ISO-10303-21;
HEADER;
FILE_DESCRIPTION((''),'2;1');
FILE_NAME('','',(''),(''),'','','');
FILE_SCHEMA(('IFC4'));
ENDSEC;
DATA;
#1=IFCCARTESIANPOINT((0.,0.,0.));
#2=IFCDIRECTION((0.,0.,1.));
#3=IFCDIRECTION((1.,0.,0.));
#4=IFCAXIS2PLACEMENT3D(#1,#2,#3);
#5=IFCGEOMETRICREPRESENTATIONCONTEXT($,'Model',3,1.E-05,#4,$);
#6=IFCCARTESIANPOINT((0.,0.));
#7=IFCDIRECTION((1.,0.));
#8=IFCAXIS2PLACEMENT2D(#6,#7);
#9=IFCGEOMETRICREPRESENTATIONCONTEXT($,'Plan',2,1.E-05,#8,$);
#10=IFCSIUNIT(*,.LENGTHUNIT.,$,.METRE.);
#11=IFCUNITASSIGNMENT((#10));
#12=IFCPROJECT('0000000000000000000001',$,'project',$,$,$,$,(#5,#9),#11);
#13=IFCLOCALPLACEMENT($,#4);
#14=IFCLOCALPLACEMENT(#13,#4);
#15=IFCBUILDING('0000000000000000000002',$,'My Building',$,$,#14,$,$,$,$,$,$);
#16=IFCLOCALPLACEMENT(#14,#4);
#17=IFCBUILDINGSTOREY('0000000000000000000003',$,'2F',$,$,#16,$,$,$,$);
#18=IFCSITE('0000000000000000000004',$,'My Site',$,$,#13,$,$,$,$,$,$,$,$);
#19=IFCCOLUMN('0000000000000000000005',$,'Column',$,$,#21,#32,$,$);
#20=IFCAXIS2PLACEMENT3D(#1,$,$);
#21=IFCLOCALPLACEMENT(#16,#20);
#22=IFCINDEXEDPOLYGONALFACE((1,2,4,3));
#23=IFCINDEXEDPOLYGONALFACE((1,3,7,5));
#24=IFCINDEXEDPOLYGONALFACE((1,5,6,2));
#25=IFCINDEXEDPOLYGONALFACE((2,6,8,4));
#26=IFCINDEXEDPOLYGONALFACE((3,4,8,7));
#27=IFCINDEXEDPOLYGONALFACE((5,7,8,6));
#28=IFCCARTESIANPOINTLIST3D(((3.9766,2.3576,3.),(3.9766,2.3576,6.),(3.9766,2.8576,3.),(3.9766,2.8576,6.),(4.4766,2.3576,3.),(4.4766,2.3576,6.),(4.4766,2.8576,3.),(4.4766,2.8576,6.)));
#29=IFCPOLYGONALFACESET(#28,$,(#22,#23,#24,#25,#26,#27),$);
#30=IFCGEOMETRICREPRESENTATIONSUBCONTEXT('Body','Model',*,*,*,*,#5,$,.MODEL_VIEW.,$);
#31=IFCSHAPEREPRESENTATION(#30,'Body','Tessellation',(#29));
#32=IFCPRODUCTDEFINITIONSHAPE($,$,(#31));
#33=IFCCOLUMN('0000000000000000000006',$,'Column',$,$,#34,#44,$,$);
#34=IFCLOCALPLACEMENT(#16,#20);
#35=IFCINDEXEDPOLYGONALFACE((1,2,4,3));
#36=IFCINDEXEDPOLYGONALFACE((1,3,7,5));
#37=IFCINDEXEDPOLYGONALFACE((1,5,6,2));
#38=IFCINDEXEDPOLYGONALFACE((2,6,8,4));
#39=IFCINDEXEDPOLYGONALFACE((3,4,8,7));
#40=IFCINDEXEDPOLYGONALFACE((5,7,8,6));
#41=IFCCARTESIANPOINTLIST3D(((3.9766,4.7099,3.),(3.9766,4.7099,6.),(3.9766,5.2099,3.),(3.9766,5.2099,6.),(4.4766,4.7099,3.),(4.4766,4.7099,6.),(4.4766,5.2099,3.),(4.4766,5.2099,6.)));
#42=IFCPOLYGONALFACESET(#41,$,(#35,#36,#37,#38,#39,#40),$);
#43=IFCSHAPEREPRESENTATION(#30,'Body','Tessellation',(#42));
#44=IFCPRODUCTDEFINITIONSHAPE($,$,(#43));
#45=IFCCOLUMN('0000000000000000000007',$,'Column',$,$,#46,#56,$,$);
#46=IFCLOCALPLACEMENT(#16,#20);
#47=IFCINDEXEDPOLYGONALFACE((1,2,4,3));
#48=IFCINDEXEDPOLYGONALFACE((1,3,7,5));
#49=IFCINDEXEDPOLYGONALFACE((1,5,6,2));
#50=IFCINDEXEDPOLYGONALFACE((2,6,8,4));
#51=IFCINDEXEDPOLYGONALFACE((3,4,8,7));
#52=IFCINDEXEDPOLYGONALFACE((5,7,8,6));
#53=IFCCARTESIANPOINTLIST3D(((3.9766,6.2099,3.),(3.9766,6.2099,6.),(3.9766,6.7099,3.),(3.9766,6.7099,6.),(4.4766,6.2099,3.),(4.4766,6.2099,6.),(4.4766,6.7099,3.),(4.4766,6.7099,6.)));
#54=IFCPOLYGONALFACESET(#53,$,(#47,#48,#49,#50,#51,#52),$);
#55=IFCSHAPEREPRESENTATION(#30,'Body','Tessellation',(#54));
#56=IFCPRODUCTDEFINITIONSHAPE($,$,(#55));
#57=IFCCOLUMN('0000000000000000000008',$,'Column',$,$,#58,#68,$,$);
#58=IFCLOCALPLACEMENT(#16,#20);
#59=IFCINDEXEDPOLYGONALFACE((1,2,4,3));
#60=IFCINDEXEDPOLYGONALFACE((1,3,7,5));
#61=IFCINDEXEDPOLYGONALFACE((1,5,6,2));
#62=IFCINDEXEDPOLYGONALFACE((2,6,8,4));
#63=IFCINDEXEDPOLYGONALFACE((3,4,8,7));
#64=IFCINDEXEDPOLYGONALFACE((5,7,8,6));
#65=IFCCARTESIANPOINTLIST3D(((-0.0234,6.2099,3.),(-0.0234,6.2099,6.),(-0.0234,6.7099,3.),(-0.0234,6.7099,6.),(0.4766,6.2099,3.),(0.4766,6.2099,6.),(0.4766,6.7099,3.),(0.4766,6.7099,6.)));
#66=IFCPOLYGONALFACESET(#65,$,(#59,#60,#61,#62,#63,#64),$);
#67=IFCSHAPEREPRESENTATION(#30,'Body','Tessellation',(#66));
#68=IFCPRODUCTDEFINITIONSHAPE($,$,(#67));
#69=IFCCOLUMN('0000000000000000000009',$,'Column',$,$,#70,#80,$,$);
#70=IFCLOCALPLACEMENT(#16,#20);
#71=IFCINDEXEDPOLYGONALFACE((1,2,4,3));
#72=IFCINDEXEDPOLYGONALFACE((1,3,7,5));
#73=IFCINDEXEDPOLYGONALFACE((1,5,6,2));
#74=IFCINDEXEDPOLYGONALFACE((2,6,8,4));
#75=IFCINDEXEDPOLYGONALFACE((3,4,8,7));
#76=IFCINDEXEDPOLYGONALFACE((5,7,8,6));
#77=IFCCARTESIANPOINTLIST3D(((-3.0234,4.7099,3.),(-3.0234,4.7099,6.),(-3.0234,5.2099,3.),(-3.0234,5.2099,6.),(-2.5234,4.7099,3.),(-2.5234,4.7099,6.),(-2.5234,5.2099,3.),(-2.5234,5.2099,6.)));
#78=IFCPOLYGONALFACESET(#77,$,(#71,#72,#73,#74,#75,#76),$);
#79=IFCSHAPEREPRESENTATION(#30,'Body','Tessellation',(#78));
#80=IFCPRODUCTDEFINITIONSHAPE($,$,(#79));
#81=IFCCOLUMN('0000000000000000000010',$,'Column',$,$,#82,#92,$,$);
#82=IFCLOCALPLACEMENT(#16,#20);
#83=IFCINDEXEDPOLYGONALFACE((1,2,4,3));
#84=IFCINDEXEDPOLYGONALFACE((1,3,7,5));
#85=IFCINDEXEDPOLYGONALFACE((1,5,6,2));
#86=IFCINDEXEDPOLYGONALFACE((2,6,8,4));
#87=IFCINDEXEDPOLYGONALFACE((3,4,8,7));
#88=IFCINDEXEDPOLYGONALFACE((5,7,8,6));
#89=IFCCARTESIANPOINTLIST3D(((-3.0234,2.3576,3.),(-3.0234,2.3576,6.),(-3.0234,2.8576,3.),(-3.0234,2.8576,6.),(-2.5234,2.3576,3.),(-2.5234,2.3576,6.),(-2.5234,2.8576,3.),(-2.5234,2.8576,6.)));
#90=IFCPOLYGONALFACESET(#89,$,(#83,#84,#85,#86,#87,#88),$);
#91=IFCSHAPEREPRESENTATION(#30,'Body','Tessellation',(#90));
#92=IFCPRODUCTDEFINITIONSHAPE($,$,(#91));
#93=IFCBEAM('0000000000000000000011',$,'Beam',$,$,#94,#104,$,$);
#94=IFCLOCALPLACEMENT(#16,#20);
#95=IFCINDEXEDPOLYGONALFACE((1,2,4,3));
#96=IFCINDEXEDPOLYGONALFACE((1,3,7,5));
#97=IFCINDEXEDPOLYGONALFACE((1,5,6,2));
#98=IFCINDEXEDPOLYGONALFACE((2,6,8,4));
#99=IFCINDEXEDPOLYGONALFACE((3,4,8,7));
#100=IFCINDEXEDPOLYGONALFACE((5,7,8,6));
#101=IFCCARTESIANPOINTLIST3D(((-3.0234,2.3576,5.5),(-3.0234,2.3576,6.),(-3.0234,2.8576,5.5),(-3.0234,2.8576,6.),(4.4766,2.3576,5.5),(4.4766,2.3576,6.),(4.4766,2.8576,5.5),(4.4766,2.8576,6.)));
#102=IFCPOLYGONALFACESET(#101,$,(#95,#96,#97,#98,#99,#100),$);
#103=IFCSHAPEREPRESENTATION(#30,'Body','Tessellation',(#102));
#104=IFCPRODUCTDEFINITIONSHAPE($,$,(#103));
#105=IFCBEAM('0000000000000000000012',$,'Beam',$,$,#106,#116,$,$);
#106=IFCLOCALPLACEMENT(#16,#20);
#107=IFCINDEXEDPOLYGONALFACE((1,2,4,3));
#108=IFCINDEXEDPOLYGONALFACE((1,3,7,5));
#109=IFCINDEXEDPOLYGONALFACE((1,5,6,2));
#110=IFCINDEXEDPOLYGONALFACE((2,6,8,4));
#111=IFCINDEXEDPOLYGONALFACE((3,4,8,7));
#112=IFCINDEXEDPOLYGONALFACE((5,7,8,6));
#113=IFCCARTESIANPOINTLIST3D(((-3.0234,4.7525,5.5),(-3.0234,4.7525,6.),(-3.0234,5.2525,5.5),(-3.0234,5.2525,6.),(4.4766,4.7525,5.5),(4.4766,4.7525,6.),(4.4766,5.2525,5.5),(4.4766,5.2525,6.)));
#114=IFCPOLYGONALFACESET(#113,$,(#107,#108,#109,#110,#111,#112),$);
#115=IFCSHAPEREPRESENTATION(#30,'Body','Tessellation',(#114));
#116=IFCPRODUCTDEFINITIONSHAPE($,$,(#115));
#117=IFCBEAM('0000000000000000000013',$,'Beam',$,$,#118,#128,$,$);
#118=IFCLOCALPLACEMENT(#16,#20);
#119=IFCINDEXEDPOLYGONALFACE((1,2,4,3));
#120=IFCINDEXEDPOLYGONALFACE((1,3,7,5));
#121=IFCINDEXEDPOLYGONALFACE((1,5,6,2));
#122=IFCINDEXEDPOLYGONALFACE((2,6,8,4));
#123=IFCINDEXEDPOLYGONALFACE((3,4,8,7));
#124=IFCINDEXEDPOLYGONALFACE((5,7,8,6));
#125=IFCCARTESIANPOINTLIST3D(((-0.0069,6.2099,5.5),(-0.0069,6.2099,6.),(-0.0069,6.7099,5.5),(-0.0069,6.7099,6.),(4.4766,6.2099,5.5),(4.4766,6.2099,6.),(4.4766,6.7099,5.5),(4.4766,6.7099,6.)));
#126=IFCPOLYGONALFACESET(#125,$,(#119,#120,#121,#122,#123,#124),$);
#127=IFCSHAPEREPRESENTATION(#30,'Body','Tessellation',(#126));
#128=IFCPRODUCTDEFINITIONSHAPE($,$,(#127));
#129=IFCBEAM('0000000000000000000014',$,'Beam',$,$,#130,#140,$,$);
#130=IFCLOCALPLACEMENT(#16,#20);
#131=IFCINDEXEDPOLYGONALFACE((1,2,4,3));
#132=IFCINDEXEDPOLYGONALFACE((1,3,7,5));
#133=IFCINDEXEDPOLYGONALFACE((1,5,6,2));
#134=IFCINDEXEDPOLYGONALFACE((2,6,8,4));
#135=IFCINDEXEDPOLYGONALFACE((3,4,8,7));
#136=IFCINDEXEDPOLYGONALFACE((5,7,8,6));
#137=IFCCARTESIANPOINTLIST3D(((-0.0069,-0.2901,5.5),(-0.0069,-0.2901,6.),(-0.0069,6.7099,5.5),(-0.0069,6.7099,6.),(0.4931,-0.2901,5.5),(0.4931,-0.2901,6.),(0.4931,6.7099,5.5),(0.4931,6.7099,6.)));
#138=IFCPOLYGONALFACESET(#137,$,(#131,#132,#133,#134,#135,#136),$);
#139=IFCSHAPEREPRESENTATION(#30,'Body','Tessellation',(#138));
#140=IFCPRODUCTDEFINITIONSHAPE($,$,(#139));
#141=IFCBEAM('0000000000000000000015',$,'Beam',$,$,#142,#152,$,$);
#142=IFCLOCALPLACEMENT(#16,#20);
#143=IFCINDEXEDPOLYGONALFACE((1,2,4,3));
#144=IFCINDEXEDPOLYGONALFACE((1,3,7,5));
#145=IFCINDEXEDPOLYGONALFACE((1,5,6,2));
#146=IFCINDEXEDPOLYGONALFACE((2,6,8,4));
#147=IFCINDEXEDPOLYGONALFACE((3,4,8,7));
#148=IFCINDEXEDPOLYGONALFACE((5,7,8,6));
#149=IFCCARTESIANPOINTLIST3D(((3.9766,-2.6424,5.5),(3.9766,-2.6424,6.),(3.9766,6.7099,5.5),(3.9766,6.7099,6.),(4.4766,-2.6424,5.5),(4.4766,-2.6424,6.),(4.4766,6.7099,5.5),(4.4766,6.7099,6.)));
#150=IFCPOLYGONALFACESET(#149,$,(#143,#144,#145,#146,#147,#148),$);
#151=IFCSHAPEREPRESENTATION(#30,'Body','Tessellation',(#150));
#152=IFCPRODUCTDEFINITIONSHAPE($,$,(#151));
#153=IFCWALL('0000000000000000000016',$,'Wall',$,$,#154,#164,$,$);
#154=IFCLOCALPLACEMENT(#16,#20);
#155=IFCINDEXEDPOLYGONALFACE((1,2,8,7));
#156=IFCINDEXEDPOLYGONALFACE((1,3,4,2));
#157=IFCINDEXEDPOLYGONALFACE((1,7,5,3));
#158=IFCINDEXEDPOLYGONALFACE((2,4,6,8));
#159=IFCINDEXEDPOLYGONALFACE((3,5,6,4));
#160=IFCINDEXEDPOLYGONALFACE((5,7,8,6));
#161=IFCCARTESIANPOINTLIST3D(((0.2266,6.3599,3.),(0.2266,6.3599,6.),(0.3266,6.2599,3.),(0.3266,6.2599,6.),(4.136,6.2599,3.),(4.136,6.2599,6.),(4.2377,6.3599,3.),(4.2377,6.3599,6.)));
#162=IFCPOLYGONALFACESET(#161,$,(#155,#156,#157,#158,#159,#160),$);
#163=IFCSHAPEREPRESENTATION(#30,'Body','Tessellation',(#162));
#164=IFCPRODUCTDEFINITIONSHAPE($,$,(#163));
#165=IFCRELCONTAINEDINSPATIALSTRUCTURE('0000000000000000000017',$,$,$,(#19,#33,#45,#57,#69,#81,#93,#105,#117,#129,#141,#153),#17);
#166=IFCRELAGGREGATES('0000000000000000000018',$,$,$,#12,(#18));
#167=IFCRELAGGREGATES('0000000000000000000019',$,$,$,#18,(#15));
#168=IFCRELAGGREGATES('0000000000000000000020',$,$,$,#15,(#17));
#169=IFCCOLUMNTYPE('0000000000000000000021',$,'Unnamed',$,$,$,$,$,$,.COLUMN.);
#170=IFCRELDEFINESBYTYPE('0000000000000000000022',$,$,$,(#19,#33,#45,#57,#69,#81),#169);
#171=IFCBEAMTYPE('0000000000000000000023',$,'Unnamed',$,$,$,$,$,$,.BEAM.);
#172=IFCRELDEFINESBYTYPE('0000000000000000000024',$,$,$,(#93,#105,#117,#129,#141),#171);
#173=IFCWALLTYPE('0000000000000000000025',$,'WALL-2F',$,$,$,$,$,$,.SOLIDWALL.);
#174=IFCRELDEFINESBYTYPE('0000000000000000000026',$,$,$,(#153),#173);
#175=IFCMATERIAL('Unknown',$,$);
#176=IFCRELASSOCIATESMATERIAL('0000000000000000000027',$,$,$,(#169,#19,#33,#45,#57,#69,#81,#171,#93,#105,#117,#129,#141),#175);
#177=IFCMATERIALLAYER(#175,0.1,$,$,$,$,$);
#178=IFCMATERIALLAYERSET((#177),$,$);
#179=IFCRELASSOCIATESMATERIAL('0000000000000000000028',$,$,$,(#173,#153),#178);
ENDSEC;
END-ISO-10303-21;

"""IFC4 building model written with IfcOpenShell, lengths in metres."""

from ifc_helpers import new_model, si_unit, frame, origin_with_axes, origin_2d_with_axis, place, context, subcontext, project, spatial, line, indexed_curve, rectangle, outline, extrude, material, layer, layer_set, layer_usage, material_profile, profile_set, profile_usage, type_object, element, save


model = new_model("IFC4")

# Units and contexts
model_context = context("Model", 3, precision=1e-05, world=origin_with_axes())
plan_context = context("Plan", 2, precision=1e-05, world=origin_2d_with_axis())
body_context_1 = subcontext(model_context, "Body", "Model", "MODEL_VIEW")
ifc_project = project(units=[si_unit("LENGTHUNIT", "METRE")], contexts=[model_context, plan_context])

# Site, building, storey
site_placement = place(None, origin_with_axes())
site = spatial("IfcSite", under=ifc_project, at=site_placement, Name="My Site")
building_placement = place(site_placement, origin_with_axes())
building = spatial("IfcBuilding", under=site, at=building_placement, Name="My Building")
storey_placement = place(building_placement, origin_with_axes())
storey = spatial("IfcBuildingStorey", under=building, at=storey_placement, Name="2F")

# Columns
ifc_material = material(Name="Unknown")
ifc_material_profile_1 = material_profile(ifc_material, rectangle(XDim=0.5, YDim=0.5))
ifc_profile_set_1 = profile_set([ifc_material_profile_1])
ifc_profile_usage_1 = profile_usage(ifc_profile_set_1, cardinal=7)
column_type = type_object("IfcColumnType", Name="Unnamed", PredefinedType="COLUMN", material=ifc_profile_set_1)
column_1_placement = place(storey_placement, frame((4.4766, 2.8576, 3.0), z_axis=(0.0, 0.0, 1.0), x_axis=(1.0, 0.0, 0.0)))
element("IfcColumn", 1, at=column_1_placement, inside=storey, type_object=column_type, material=ifc_profile_usage_1, Name="Column", context=body_context_1, shape_type="SweptSolid", body=[
    extrude(rectangle(XDim=0.5, YDim=0.5), frame((-0.25, -0.25, 0.0), z_axis=(0.0, 0.0, 1.0), x_axis=(1.0, 0.0, 0.0)), (0.0, 0.0, 1.0), 3.0),
])
ifc_profile_usage_2 = profile_usage(ifc_profile_set_1, cardinal=7)
column_2_placement = place(storey_placement, frame((4.4766, 5.2099, 3.0), z_axis=(0.0, 0.0, 1.0), x_axis=(1.0, 0.0, 0.0)))
element("IfcColumn", 2, at=column_2_placement, inside=storey, type_object=column_type, material=ifc_profile_usage_2, Name="Column", context=body_context_1, shape_type="SweptSolid", body=[
    extrude(rectangle(XDim=0.5, YDim=0.5), frame((-0.25, -0.25, 0.0), z_axis=(0.0, 0.0, 1.0), x_axis=(1.0, 0.0, 0.0)), (0.0, 0.0, 1.0), 3.0),
])
ifc_profile_usage_3 = profile_usage(ifc_profile_set_1, cardinal=7)
column_3_placement = place(storey_placement, frame((4.4766, 6.7099, 3.0), z_axis=(0.0, 0.0, 1.0), x_axis=(1.0, 0.0, 0.0)))
element("IfcColumn", 3, at=column_3_placement, inside=storey, type_object=column_type, material=ifc_profile_usage_3, Name="Column", context=body_context_1, shape_type="SweptSolid", body=[
    extrude(rectangle(XDim=0.5, YDim=0.5), frame((-0.25, -0.25, 0.0), z_axis=(0.0, 0.0, 1.0), x_axis=(1.0, 0.0, 0.0)), (0.0, 0.0, 1.0), 3.0),
])
ifc_profile_usage_4 = profile_usage(ifc_profile_set_1, cardinal=7)
column_4_placement = place(storey_placement, frame((0.4766, 6.7099, 3.0), z_axis=(0.0, 0.0, 1.0), x_axis=(1.0, 0.0, 0.0)))
element("IfcColumn", 4, at=column_4_placement, inside=storey, type_object=column_type, material=ifc_profile_usage_4, Name="Column", context=body_context_1, shape_type="SweptSolid", body=[
    extrude(rectangle(XDim=0.5, YDim=0.5), frame((-0.25, -0.25, 0.0), z_axis=(0.0, 0.0, 1.0), x_axis=(1.0, 0.0, 0.0)), (0.0, 0.0, 1.0), 3.0),
])
ifc_profile_usage_5 = profile_usage(ifc_profile_set_1, cardinal=7)
column_5_placement = place(storey_placement, frame((-2.5234, 5.2099, 3.0), z_axis=(0.0, 0.0, 1.0), x_axis=(1.0, 0.0, 0.0)))
element("IfcColumn", 5, at=column_5_placement, inside=storey, type_object=column_type, material=ifc_profile_usage_5, Name="Column", context=body_context_1, shape_type="SweptSolid", body=[
    extrude(rectangle(XDim=0.5, YDim=0.5), frame((-0.25, -0.25, 0.0), z_axis=(0.0, 0.0, 1.0), x_axis=(1.0, 0.0, 0.0)), (0.0, 0.0, 1.0), 3.0),
])
ifc_profile_usage_6 = profile_usage(ifc_profile_set_1, cardinal=7)
column_6_placement = place(storey_placement, frame((-2.5234, 2.8576, 3.0), z_axis=(0.0, 0.0, 1.0), x_axis=(1.0, 0.0, 0.0)))
element("IfcColumn", 6, at=column_6_placement, inside=storey, type_object=column_type, material=ifc_profile_usage_6, Name="Column", context=body_context_1, shape_type="SweptSolid", body=[
    extrude(rectangle(XDim=0.5, YDim=0.5), frame((-0.25, -0.25, 0.0), z_axis=(0.0, 0.0, 1.0), x_axis=(1.0, 0.0, 0.0)), (0.0, 0.0, 1.0), 3.0),
])

# Beams
ifc_material_profile_2 = material_profile(ifc_material, rectangle(XDim=0.5, YDim=0.5))
ifc_profile_set_2 = profile_set([ifc_material_profile_2])
ifc_profile_usage_7 = profile_usage(ifc_profile_set_2, cardinal=7)
beam_type = type_object("IfcBeamType", Name="Unnamed", PredefinedType="BEAM", material=ifc_profile_set_2)
beam_1_placement = place(storey_placement, frame((-3.0234, 2.8576, 6.0), z_axis=(1.0, 0.0, 0.0), x_axis=(0.0, 1.0, 0.0)))
element("IfcBeam", 7, at=beam_1_placement, inside=storey, type_object=beam_type, material=ifc_profile_usage_7, Name="Beam", context=body_context_1, shape_type="SweptSolid", body=[
    extrude(rectangle(XDim=0.5, YDim=0.5), frame((-0.25, -0.25, 0.0), z_axis=(0.0, 0.0, 1.0), x_axis=(1.0, 0.0, 0.0)), (0.0, 0.0, 1.0), 7.5),
])
ifc_profile_usage_8 = profile_usage(ifc_profile_set_2, cardinal=7)
beam_2_placement = place(storey_placement, frame((-3.0234, 5.2525, 6.0), z_axis=(1.0, 0.0, 0.0), x_axis=(0.0, 1.0, 0.0)))
element("IfcBeam", 8, at=beam_2_placement, inside=storey, type_object=beam_type, material=ifc_profile_usage_8, Name="Beam", context=body_context_1, shape_type="SweptSolid", body=[
    extrude(rectangle(XDim=0.5, YDim=0.5), frame((-0.25, -0.25, 0.0), z_axis=(0.0, 0.0, 1.0), x_axis=(1.0, 0.0, 0.0)), (0.0, 0.0, 1.0), 7.5),
])
ifc_profile_usage_9 = profile_usage(ifc_profile_set_2, cardinal=7)
beam_3_placement = place(storey_placement, frame((-0.0069, 6.7099, 6.0), z_axis=(1.0, -0.000001, 0.000001), x_axis=(0.000001, 1.0, 0.0)))
element("IfcBeam", 9, at=beam_3_placement, inside=storey, type_object=beam_type, material=ifc_profile_usage_9, Name="Beam", context=body_context_1, shape_type="SweptSolid", body=[
    extrude(rectangle(XDim=0.5, YDim=0.5), frame((-0.25, -0.25, 0.0), z_axis=(0.0, 0.0, 1.0), x_axis=(1.0, 0.0, 0.0)), (0.0, 0.0, 1.0), 4.4835),
])
ifc_profile_usage_10 = profile_usage(ifc_profile_set_2, cardinal=7)
beam_4_placement = place(storey_placement, frame((0.4931, 6.7099, 6.0), z_axis=(0.0, -1.0, 0.0), x_axis=(1.0, 0.0, 0.0)))
element("IfcBeam", 10, at=beam_4_placement, inside=storey, type_object=beam_type, material=ifc_profile_usage_10, Name="Beam", context=body_context_1, shape_type="SweptSolid", body=[
    extrude(rectangle(XDim=0.5, YDim=0.5), frame((-0.25, -0.25, 0.0), z_axis=(0.0, 0.0, 1.0), x_axis=(1.0, 0.0, 0.0)), (0.0, 0.0, 1.0), 7.0),
])
ifc_profile_usage_11 = profile_usage(ifc_profile_set_2, cardinal=7)
beam_5_placement = place(storey_placement, frame((4.4766, 6.7099, 6.0), z_axis=(0.0, -1.0, 0.0), x_axis=(1.0, 0.0, 0.0)))
element("IfcBeam", 11, at=beam_5_placement, inside=storey, type_object=beam_type, material=ifc_profile_usage_11, Name="Beam", context=body_context_1, shape_type="SweptSolid", body=[
    extrude(rectangle(XDim=0.5, YDim=0.5), frame((-0.25, -0.25, 0.0), z_axis=(0.0, 0.0, 1.0), x_axis=(1.0, 0.0, 0.0)), (0.0, 0.0, 1.0), 9.3523),
])

# Wall
ifc_layer = layer(ifc_material, 0.1)
ifc_layer_set = layer_set([ifc_layer])
ifc_layer_usage_1 = layer_usage(ifc_layer_set, "AXIS2", "POSITIVE", 0.0)
wall_type = type_object("IfcWallType", Name="WALL-2F", PredefinedType="SOLIDWALL", material=ifc_layer_set)
wall_1_placement = place(storey_placement, frame((4.2377, 6.3599, 3.0), z_axis=(0.0, 0.0, 1.0), x_axis=(-1.0, 0.0, 0.0)))
element("IfcWall", 12, at=wall_1_placement, inside=storey, type_object=wall_type, material=ifc_layer_usage_1, Name="Wall", context=body_context_1, shape_type="SweptSolid", body=[
    extrude(outline(indexed_curve([(0.0, 0.0), (0.1017, 0.1), (3.9111, 0.1), (4.0111, 0.0)], segments=[line(1, 2, 3, 4, 1)])), origin_with_axes(), (0.0, 0.0, 1.0), 3.0),
])

save(model, "model.ifc")
